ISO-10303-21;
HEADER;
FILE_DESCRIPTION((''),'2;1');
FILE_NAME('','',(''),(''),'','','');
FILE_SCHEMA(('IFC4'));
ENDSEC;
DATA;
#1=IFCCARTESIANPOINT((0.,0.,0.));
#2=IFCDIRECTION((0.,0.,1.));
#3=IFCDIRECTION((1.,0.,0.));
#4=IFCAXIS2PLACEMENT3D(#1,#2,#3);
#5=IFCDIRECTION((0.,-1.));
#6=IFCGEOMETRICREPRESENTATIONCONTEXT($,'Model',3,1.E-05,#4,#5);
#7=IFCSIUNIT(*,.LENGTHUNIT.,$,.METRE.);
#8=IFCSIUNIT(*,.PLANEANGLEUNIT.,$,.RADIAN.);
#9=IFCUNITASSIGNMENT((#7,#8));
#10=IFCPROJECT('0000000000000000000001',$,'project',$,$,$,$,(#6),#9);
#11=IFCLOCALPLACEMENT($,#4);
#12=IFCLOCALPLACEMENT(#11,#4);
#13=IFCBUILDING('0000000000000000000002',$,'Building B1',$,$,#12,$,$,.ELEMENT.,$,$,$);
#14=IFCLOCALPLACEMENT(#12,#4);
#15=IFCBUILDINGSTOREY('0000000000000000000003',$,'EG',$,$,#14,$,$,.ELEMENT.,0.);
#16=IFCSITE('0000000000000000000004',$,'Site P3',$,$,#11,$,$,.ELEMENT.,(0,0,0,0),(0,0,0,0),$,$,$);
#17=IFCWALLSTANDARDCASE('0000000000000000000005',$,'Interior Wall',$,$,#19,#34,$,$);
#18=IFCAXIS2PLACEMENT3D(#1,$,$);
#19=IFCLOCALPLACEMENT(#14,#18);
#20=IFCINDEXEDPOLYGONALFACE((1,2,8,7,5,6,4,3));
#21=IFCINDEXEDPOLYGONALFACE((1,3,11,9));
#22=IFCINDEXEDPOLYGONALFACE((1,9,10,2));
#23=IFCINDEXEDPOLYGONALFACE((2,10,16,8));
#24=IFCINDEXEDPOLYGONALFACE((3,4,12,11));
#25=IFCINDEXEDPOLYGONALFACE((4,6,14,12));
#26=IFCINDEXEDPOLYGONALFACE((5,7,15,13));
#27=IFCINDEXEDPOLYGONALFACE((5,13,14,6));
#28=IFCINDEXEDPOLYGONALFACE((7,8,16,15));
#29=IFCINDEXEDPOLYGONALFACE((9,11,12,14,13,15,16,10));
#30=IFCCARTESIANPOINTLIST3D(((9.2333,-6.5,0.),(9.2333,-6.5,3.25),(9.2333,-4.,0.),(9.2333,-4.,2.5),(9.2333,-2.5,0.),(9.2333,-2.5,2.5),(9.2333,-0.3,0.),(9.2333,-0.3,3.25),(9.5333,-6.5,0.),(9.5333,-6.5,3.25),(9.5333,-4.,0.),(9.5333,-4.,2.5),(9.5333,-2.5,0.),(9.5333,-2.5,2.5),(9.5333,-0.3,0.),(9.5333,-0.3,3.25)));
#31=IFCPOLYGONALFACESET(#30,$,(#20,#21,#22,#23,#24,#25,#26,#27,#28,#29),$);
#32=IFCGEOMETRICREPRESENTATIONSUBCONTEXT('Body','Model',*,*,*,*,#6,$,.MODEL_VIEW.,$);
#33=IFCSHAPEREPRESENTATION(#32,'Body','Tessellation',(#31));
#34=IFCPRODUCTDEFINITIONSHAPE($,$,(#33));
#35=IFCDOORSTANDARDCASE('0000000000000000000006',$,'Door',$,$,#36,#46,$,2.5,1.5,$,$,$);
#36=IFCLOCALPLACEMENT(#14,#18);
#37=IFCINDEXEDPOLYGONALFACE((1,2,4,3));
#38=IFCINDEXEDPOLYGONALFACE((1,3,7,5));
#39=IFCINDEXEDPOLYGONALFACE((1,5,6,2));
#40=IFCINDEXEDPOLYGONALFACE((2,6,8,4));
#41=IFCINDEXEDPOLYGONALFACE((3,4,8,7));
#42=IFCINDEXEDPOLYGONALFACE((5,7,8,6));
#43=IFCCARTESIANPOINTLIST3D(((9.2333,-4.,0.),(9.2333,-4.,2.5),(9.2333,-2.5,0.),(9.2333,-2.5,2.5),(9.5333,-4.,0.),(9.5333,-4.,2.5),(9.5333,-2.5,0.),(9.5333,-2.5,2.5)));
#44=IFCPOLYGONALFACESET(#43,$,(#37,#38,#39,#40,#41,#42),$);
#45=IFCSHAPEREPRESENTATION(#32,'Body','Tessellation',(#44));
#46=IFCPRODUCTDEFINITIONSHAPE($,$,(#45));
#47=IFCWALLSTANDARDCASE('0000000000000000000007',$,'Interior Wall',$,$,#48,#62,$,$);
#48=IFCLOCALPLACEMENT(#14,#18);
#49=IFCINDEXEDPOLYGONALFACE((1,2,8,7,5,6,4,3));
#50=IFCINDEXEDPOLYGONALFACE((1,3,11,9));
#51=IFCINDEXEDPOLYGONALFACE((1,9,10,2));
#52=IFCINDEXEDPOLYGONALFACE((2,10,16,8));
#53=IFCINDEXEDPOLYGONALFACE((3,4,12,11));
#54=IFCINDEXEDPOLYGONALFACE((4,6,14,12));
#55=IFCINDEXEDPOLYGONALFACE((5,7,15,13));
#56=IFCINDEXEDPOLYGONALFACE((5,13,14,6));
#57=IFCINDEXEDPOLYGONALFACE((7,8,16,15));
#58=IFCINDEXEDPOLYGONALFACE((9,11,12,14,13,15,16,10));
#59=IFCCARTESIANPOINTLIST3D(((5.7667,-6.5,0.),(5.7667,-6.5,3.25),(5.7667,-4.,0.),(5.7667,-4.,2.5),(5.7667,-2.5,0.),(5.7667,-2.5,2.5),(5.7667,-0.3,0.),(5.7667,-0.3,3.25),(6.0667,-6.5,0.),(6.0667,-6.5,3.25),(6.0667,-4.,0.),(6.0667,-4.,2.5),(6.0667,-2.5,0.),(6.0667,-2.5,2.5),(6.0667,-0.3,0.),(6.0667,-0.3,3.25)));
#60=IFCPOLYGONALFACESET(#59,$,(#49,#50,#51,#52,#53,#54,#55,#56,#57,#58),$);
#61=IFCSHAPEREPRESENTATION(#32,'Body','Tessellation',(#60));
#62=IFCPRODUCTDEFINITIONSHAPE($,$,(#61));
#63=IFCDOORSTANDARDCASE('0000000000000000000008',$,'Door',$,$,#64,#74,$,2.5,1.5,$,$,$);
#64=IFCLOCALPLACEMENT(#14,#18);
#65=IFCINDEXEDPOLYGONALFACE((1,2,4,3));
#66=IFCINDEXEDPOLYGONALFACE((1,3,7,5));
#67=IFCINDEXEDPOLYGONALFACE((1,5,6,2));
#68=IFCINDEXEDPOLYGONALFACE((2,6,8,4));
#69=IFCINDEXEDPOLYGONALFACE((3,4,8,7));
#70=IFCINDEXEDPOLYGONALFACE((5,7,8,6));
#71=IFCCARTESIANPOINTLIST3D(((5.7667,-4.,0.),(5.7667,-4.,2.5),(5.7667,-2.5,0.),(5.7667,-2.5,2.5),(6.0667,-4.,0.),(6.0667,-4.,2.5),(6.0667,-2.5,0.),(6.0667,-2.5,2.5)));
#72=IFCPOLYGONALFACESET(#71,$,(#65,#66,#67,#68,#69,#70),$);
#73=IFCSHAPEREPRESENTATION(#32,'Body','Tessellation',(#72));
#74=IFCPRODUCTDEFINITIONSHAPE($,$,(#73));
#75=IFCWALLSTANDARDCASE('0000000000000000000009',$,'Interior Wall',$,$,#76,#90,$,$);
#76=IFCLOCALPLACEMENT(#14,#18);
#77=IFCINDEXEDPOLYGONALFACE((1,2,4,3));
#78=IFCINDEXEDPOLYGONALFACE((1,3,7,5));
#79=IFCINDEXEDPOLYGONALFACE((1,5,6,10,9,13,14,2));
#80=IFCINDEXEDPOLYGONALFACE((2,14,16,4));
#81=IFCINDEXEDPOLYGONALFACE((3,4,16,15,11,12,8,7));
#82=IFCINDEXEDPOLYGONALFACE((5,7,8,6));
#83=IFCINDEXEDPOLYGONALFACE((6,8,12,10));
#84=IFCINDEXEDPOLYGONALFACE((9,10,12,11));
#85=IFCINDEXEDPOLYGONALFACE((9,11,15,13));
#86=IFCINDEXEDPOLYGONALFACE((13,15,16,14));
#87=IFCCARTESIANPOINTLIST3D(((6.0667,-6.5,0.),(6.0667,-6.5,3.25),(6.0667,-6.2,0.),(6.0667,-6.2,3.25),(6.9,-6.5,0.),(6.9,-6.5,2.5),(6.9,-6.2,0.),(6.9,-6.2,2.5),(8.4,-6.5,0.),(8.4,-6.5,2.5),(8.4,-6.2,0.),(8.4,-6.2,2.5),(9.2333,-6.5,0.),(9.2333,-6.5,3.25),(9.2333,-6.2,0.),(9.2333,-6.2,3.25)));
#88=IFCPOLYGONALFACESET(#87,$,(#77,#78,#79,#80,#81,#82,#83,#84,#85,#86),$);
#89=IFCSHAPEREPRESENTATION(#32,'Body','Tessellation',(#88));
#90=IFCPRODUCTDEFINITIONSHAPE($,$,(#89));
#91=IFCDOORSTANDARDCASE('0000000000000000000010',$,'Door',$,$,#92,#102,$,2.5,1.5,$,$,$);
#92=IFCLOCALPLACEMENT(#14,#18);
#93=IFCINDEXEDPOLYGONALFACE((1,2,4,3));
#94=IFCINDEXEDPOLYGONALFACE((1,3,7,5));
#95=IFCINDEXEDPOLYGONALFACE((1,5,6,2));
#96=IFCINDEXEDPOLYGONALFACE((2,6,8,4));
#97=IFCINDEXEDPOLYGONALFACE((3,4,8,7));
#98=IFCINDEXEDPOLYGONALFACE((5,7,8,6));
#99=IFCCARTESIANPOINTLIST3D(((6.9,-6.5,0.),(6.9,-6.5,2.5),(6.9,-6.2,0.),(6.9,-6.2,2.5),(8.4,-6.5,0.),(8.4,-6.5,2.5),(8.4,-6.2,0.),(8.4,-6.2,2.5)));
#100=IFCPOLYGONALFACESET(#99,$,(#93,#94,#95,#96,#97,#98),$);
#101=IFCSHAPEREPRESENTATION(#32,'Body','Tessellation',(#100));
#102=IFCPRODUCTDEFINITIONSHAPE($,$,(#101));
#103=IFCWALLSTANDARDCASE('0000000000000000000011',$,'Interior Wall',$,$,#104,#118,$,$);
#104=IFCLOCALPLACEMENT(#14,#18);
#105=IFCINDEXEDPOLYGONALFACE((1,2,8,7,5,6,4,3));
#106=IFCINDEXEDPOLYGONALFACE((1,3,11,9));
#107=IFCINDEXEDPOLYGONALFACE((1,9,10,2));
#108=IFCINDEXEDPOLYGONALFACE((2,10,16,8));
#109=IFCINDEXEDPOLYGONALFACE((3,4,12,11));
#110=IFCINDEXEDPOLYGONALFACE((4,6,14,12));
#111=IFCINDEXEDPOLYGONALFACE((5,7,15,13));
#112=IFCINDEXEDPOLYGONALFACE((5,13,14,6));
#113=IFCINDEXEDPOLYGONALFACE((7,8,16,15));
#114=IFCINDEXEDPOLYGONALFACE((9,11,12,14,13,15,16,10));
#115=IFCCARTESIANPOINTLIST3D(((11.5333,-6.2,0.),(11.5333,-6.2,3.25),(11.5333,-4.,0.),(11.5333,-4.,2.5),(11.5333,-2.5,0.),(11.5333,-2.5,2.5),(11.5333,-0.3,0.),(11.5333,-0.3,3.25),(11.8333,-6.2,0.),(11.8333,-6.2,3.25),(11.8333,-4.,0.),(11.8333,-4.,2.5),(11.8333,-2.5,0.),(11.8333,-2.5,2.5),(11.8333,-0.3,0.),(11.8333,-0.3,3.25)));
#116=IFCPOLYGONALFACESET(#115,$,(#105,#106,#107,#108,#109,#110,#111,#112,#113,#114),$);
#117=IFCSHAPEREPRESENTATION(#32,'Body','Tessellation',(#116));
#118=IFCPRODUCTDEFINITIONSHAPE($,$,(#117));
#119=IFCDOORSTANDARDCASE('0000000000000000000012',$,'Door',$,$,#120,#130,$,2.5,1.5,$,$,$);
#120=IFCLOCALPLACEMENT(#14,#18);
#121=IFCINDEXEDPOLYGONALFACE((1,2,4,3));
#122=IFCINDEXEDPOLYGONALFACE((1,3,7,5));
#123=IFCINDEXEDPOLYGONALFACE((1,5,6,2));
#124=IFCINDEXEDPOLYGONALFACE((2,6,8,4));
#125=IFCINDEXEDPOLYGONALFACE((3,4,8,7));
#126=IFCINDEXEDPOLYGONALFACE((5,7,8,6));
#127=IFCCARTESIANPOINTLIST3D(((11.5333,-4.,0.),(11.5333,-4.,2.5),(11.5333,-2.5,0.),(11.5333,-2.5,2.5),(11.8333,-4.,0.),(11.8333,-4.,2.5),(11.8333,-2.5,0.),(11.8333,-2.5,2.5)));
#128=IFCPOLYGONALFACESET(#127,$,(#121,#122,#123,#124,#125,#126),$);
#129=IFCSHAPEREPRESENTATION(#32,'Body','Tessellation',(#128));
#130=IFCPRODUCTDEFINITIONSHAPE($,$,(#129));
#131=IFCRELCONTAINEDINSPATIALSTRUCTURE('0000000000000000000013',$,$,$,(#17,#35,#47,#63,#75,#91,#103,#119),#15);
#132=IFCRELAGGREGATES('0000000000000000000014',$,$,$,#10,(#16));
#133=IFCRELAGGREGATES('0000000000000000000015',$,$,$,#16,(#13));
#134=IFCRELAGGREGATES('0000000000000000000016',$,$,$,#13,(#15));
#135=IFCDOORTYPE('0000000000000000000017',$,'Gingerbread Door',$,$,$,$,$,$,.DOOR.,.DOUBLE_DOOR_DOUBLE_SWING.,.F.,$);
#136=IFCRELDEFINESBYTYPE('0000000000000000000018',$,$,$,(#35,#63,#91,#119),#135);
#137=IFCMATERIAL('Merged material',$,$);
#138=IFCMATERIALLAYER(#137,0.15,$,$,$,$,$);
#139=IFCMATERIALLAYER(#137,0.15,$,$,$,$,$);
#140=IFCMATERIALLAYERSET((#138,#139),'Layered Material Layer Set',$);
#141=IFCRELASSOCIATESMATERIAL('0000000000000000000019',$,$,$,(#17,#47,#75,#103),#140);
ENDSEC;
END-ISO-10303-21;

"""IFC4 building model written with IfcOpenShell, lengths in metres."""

from ifc_helpers import new_model, si_unit, direction, frame, origin_with_axes, place, context, subcontext, project, spatial, polyline, outline, extrude, source, transform, mapped, material, layer, layer_set, layer_usage, type_object, element, fill, save


model = new_model("IFC4")

# Units and contexts
model_context = context("Model", 3, precision=1e-05, world=origin_with_axes(), true_north=direction((0.0, -1.0)))
body_context = subcontext(model_context, "Body", "Model", "MODEL_VIEW")
ifc_project = project(units=[si_unit("LENGTHUNIT", "METRE"), si_unit("PLANEANGLEUNIT", "RADIAN")], contexts=[model_context])

# Site, building, storey
site_placement = place(None, origin_with_axes())
site = spatial("IfcSite", under=ifc_project, at=site_placement, Name="Site P3", CompositionType="ELEMENT", RefLatitude=(0, 0, 0, 0), RefLongitude=(0, 0, 0, 0))
building_placement = place(site_placement, origin_with_axes())
building = spatial("IfcBuilding", under=site, at=building_placement, Name="Building B1", CompositionType="ELEMENT")
storey_placement = place(building_placement, origin_with_axes())
storey = spatial("IfcBuildingStorey", under=building, at=storey_placement, Name="EG", CompositionType="ELEMENT", Elevation=0.0)

# Shared definitions
ifc_material = material(Name="Merged material")

# Shared definitions
ifc_layer_1 = layer(ifc_material, 0.15)
ifc_layer_2 = layer(ifc_material, 0.15)
ifc_layer_set_1 = layer_set([ifc_layer_1, ifc_layer_2], Name="Layered Material Layer Set")
ifc_layer_usage_1 = layer_usage(ifc_layer_set_1, "AXIS2", "POSITIVE", -0.15)
door_type = type_object("IfcDoorType", Name="Gingerbread Door", OperationType="DOUBLE_DOOR_DOUBLE_SWING", ParameterTakesPrecedence=False, PredefinedType="DOOR")
shared_shape_1 = source(origin_with_axes(), body_context, "Body", "SweptSolid", [
    extrude(outline(polyline([(0.0, 0.0), (0.0, 1.5), (2.5, 1.5), (2.5, 0.0), (0.0, 0.0)])), frame((0.0, -0.15, 0.0), z_axis=(0.0, 1.0, 0.0), x_axis=(0.0, 0.0, 1.0)), (0.0, 0.0, 1.0), 0.3),
])

# Walls, openings, doors
wall_1_placement = place(storey_placement, frame((9.3833, -0.3, 0.0), z_axis=(0.0, 0.0, 1.0), x_axis=(0.0, -1.0, 0.0)))
wall_1 = element("IfcWallStandardCase", 1, at=wall_1_placement, inside=storey, material=ifc_layer_usage_1, Name="Interior Wall", context=body_context, shape_type="SweptSolid", body=[
    extrude(outline(polyline([(0.0, 0.15), (6.2, 0.15), (6.2, -0.15), (0.0, -0.15), (0.0, 0.15)])), origin_with_axes(), (0.0, 0.0, 1.0), 3.25),
])
opening_1_placement = place(wall_1_placement, frame((2.2, 0.0, 0.0), z_axis=(0.0, 0.0, 1.0), x_axis=(1.0, 0.0, 0.0)))
opening_1 = element("IfcOpeningStandardCase", 2, at=opening_1_placement, cuts=wall_1, context=body_context, shape_type="SweptSolid", body=[
    extrude(outline(polyline([(0.0, 0.0), (0.0, 1.5), (2.5, 1.5), (2.5, 0.0), (0.0, 0.0)])), frame((0.0, -0.15, 0.0), z_axis=(0.0, 1.0, 0.0), x_axis=(0.0, 0.0, 1.0)), (0.0, 0.0, 1.0), 0.3),
])
door_1_placement = place(opening_1_placement, origin_with_axes())
door_1 = element("IfcDoorStandardCase", 3, at=door_1_placement, inside=storey, type_object=door_type, Name="Door", OverallHeight=2.5, OverallWidth=1.5, context=body_context, shape_type="MappedRepresentation", body=[
    mapped(shared_shape_1, transform((0.0, 0.0, 0.0))),
])
fill(opening_1, door_1)
wall_2_placement = place(storey_placement, frame((5.9167, -0.3, 0.0), z_axis=(0.0, 0.0, 1.0), x_axis=(0.0, -1.0, 0.0)))
wall_2 = element("IfcWallStandardCase", 4, at=wall_2_placement, inside=storey, material=ifc_layer_usage_1, Name="Interior Wall", context=body_context, shape_type="SweptSolid", body=[
    extrude(outline(polyline([(0.0, 0.15), (6.2, 0.15), (6.2, -0.15), (0.0, -0.15), (0.0, 0.15)])), origin_with_axes(), (0.0, 0.0, 1.0), 3.25),
])
opening_2_placement = place(wall_2_placement, frame((2.2, 0.0, 0.0), z_axis=(0.0, 0.0, 1.0), x_axis=(1.0, 0.0, 0.0)))
opening_2 = element("IfcOpeningStandardCase", 5, at=opening_2_placement, cuts=wall_2, context=body_context, shape_type="SweptSolid", body=[
    extrude(outline(polyline([(0.0, 0.0), (0.0, 1.5), (2.5, 1.5), (2.5, 0.0), (0.0, 0.0)])), frame((0.0, -0.15, 0.0), z_axis=(0.0, 1.0, 0.0), x_axis=(0.0, 0.0, 1.0)), (0.0, 0.0, 1.0), 0.3),
])
door_2_placement = place(opening_2_placement, origin_with_axes())
door_2 = element("IfcDoorStandardCase", 6, at=door_2_placement, inside=storey, type_object=door_type, Name="Door", OverallHeight=2.5, OverallWidth=1.5, context=body_context, shape_type="MappedRepresentation", body=[
    mapped(shared_shape_1, transform((0.0, 0.0, 0.0))),
])
fill(opening_2, door_2)
wall_3_placement = place(storey_placement, frame((6.0667, -6.35, 0.0), z_axis=(0.0, 0.0, 1.0), x_axis=(1.0, 0.0, 0.0)))
wall_3 = element("IfcWallStandardCase", 7, at=wall_3_placement, inside=storey, material=ifc_layer_usage_1, Name="Interior Wall", context=body_context, shape_type="SweptSolid", body=[
    extrude(outline(polyline([(0.0, 0.15), (3.1667, 0.15), (3.1667, -0.15), (0.0, -0.15), (0.0, 0.15)])), origin_with_axes(), (0.0, 0.0, 1.0), 3.25),
])
opening_3_placement = place(wall_3_placement, frame((0.8333, 0.0, 0.0), z_axis=(0.0, 0.0, 1.0), x_axis=(1.0, 0.0, 0.0)))
opening_3 = element("IfcOpeningStandardCase", 8, at=opening_3_placement, cuts=wall_3, context=body_context, shape_type="SweptSolid", body=[
    extrude(outline(polyline([(0.0, 0.0), (0.0, 1.5), (2.5, 1.5), (2.5, 0.0), (0.0, 0.0)])), frame((0.0, -0.15, 0.0), z_axis=(0.0, 1.0, 0.0), x_axis=(0.0, 0.0, 1.0)), (0.0, 0.0, 1.0), 0.3),
])
door_3_placement = place(opening_3_placement, origin_with_axes())
door_3 = element("IfcDoorStandardCase", 9, at=door_3_placement, inside=storey, type_object=door_type, Name="Door", OverallHeight=2.5, OverallWidth=1.5, context=body_context, shape_type="MappedRepresentation", body=[
    mapped(shared_shape_1, transform((0.0, 0.0, 0.0))),
])
fill(opening_3, door_3)
wall_4_placement = place(storey_placement, frame((11.6833, -0.3, 0.0), z_axis=(0.0, 0.0, 1.0), x_axis=(0.0, -1.0, 0.0)))
wall_4 = element("IfcWallStandardCase", 10, at=wall_4_placement, inside=storey, material=ifc_layer_usage_1, Name="Interior Wall", context=body_context, shape_type="SweptSolid", body=[
    extrude(outline(polyline([(0.0, 0.15), (5.9, 0.15), (5.9, -0.15), (0.0, -0.15), (0.0, 0.15)])), origin_with_axes(), (0.0, 0.0, 1.0), 3.25),
])
opening_4_placement = place(wall_4_placement, frame((2.2, 0.0, 0.0), z_axis=(0.0, 0.0, 1.0), x_axis=(1.0, 0.0, 0.0)))
opening_4 = element("IfcOpeningStandardCase", 11, at=opening_4_placement, cuts=wall_4, context=body_context, shape_type="SweptSolid", body=[
    extrude(outline(polyline([(0.0, 0.0), (0.0, 1.5), (2.5, 1.5), (2.5, 0.0), (0.0, 0.0)])), frame((0.0, -0.15, 0.0), z_axis=(0.0, 1.0, 0.0), x_axis=(0.0, 0.0, 1.0)), (0.0, 0.0, 1.0), 0.3),
])
door_4_placement = place(opening_4_placement, origin_with_axes())
door_4 = element("IfcDoorStandardCase", 12, at=door_4_placement, inside=storey, type_object=door_type, Name="Door", OverallHeight=2.5, OverallWidth=1.5, context=body_context, shape_type="MappedRepresentation", body=[
    mapped(shared_shape_1, transform((0.0, 0.0, 0.0))),
])
fill(opening_4, door_4)

save(model, "model.ifc")
